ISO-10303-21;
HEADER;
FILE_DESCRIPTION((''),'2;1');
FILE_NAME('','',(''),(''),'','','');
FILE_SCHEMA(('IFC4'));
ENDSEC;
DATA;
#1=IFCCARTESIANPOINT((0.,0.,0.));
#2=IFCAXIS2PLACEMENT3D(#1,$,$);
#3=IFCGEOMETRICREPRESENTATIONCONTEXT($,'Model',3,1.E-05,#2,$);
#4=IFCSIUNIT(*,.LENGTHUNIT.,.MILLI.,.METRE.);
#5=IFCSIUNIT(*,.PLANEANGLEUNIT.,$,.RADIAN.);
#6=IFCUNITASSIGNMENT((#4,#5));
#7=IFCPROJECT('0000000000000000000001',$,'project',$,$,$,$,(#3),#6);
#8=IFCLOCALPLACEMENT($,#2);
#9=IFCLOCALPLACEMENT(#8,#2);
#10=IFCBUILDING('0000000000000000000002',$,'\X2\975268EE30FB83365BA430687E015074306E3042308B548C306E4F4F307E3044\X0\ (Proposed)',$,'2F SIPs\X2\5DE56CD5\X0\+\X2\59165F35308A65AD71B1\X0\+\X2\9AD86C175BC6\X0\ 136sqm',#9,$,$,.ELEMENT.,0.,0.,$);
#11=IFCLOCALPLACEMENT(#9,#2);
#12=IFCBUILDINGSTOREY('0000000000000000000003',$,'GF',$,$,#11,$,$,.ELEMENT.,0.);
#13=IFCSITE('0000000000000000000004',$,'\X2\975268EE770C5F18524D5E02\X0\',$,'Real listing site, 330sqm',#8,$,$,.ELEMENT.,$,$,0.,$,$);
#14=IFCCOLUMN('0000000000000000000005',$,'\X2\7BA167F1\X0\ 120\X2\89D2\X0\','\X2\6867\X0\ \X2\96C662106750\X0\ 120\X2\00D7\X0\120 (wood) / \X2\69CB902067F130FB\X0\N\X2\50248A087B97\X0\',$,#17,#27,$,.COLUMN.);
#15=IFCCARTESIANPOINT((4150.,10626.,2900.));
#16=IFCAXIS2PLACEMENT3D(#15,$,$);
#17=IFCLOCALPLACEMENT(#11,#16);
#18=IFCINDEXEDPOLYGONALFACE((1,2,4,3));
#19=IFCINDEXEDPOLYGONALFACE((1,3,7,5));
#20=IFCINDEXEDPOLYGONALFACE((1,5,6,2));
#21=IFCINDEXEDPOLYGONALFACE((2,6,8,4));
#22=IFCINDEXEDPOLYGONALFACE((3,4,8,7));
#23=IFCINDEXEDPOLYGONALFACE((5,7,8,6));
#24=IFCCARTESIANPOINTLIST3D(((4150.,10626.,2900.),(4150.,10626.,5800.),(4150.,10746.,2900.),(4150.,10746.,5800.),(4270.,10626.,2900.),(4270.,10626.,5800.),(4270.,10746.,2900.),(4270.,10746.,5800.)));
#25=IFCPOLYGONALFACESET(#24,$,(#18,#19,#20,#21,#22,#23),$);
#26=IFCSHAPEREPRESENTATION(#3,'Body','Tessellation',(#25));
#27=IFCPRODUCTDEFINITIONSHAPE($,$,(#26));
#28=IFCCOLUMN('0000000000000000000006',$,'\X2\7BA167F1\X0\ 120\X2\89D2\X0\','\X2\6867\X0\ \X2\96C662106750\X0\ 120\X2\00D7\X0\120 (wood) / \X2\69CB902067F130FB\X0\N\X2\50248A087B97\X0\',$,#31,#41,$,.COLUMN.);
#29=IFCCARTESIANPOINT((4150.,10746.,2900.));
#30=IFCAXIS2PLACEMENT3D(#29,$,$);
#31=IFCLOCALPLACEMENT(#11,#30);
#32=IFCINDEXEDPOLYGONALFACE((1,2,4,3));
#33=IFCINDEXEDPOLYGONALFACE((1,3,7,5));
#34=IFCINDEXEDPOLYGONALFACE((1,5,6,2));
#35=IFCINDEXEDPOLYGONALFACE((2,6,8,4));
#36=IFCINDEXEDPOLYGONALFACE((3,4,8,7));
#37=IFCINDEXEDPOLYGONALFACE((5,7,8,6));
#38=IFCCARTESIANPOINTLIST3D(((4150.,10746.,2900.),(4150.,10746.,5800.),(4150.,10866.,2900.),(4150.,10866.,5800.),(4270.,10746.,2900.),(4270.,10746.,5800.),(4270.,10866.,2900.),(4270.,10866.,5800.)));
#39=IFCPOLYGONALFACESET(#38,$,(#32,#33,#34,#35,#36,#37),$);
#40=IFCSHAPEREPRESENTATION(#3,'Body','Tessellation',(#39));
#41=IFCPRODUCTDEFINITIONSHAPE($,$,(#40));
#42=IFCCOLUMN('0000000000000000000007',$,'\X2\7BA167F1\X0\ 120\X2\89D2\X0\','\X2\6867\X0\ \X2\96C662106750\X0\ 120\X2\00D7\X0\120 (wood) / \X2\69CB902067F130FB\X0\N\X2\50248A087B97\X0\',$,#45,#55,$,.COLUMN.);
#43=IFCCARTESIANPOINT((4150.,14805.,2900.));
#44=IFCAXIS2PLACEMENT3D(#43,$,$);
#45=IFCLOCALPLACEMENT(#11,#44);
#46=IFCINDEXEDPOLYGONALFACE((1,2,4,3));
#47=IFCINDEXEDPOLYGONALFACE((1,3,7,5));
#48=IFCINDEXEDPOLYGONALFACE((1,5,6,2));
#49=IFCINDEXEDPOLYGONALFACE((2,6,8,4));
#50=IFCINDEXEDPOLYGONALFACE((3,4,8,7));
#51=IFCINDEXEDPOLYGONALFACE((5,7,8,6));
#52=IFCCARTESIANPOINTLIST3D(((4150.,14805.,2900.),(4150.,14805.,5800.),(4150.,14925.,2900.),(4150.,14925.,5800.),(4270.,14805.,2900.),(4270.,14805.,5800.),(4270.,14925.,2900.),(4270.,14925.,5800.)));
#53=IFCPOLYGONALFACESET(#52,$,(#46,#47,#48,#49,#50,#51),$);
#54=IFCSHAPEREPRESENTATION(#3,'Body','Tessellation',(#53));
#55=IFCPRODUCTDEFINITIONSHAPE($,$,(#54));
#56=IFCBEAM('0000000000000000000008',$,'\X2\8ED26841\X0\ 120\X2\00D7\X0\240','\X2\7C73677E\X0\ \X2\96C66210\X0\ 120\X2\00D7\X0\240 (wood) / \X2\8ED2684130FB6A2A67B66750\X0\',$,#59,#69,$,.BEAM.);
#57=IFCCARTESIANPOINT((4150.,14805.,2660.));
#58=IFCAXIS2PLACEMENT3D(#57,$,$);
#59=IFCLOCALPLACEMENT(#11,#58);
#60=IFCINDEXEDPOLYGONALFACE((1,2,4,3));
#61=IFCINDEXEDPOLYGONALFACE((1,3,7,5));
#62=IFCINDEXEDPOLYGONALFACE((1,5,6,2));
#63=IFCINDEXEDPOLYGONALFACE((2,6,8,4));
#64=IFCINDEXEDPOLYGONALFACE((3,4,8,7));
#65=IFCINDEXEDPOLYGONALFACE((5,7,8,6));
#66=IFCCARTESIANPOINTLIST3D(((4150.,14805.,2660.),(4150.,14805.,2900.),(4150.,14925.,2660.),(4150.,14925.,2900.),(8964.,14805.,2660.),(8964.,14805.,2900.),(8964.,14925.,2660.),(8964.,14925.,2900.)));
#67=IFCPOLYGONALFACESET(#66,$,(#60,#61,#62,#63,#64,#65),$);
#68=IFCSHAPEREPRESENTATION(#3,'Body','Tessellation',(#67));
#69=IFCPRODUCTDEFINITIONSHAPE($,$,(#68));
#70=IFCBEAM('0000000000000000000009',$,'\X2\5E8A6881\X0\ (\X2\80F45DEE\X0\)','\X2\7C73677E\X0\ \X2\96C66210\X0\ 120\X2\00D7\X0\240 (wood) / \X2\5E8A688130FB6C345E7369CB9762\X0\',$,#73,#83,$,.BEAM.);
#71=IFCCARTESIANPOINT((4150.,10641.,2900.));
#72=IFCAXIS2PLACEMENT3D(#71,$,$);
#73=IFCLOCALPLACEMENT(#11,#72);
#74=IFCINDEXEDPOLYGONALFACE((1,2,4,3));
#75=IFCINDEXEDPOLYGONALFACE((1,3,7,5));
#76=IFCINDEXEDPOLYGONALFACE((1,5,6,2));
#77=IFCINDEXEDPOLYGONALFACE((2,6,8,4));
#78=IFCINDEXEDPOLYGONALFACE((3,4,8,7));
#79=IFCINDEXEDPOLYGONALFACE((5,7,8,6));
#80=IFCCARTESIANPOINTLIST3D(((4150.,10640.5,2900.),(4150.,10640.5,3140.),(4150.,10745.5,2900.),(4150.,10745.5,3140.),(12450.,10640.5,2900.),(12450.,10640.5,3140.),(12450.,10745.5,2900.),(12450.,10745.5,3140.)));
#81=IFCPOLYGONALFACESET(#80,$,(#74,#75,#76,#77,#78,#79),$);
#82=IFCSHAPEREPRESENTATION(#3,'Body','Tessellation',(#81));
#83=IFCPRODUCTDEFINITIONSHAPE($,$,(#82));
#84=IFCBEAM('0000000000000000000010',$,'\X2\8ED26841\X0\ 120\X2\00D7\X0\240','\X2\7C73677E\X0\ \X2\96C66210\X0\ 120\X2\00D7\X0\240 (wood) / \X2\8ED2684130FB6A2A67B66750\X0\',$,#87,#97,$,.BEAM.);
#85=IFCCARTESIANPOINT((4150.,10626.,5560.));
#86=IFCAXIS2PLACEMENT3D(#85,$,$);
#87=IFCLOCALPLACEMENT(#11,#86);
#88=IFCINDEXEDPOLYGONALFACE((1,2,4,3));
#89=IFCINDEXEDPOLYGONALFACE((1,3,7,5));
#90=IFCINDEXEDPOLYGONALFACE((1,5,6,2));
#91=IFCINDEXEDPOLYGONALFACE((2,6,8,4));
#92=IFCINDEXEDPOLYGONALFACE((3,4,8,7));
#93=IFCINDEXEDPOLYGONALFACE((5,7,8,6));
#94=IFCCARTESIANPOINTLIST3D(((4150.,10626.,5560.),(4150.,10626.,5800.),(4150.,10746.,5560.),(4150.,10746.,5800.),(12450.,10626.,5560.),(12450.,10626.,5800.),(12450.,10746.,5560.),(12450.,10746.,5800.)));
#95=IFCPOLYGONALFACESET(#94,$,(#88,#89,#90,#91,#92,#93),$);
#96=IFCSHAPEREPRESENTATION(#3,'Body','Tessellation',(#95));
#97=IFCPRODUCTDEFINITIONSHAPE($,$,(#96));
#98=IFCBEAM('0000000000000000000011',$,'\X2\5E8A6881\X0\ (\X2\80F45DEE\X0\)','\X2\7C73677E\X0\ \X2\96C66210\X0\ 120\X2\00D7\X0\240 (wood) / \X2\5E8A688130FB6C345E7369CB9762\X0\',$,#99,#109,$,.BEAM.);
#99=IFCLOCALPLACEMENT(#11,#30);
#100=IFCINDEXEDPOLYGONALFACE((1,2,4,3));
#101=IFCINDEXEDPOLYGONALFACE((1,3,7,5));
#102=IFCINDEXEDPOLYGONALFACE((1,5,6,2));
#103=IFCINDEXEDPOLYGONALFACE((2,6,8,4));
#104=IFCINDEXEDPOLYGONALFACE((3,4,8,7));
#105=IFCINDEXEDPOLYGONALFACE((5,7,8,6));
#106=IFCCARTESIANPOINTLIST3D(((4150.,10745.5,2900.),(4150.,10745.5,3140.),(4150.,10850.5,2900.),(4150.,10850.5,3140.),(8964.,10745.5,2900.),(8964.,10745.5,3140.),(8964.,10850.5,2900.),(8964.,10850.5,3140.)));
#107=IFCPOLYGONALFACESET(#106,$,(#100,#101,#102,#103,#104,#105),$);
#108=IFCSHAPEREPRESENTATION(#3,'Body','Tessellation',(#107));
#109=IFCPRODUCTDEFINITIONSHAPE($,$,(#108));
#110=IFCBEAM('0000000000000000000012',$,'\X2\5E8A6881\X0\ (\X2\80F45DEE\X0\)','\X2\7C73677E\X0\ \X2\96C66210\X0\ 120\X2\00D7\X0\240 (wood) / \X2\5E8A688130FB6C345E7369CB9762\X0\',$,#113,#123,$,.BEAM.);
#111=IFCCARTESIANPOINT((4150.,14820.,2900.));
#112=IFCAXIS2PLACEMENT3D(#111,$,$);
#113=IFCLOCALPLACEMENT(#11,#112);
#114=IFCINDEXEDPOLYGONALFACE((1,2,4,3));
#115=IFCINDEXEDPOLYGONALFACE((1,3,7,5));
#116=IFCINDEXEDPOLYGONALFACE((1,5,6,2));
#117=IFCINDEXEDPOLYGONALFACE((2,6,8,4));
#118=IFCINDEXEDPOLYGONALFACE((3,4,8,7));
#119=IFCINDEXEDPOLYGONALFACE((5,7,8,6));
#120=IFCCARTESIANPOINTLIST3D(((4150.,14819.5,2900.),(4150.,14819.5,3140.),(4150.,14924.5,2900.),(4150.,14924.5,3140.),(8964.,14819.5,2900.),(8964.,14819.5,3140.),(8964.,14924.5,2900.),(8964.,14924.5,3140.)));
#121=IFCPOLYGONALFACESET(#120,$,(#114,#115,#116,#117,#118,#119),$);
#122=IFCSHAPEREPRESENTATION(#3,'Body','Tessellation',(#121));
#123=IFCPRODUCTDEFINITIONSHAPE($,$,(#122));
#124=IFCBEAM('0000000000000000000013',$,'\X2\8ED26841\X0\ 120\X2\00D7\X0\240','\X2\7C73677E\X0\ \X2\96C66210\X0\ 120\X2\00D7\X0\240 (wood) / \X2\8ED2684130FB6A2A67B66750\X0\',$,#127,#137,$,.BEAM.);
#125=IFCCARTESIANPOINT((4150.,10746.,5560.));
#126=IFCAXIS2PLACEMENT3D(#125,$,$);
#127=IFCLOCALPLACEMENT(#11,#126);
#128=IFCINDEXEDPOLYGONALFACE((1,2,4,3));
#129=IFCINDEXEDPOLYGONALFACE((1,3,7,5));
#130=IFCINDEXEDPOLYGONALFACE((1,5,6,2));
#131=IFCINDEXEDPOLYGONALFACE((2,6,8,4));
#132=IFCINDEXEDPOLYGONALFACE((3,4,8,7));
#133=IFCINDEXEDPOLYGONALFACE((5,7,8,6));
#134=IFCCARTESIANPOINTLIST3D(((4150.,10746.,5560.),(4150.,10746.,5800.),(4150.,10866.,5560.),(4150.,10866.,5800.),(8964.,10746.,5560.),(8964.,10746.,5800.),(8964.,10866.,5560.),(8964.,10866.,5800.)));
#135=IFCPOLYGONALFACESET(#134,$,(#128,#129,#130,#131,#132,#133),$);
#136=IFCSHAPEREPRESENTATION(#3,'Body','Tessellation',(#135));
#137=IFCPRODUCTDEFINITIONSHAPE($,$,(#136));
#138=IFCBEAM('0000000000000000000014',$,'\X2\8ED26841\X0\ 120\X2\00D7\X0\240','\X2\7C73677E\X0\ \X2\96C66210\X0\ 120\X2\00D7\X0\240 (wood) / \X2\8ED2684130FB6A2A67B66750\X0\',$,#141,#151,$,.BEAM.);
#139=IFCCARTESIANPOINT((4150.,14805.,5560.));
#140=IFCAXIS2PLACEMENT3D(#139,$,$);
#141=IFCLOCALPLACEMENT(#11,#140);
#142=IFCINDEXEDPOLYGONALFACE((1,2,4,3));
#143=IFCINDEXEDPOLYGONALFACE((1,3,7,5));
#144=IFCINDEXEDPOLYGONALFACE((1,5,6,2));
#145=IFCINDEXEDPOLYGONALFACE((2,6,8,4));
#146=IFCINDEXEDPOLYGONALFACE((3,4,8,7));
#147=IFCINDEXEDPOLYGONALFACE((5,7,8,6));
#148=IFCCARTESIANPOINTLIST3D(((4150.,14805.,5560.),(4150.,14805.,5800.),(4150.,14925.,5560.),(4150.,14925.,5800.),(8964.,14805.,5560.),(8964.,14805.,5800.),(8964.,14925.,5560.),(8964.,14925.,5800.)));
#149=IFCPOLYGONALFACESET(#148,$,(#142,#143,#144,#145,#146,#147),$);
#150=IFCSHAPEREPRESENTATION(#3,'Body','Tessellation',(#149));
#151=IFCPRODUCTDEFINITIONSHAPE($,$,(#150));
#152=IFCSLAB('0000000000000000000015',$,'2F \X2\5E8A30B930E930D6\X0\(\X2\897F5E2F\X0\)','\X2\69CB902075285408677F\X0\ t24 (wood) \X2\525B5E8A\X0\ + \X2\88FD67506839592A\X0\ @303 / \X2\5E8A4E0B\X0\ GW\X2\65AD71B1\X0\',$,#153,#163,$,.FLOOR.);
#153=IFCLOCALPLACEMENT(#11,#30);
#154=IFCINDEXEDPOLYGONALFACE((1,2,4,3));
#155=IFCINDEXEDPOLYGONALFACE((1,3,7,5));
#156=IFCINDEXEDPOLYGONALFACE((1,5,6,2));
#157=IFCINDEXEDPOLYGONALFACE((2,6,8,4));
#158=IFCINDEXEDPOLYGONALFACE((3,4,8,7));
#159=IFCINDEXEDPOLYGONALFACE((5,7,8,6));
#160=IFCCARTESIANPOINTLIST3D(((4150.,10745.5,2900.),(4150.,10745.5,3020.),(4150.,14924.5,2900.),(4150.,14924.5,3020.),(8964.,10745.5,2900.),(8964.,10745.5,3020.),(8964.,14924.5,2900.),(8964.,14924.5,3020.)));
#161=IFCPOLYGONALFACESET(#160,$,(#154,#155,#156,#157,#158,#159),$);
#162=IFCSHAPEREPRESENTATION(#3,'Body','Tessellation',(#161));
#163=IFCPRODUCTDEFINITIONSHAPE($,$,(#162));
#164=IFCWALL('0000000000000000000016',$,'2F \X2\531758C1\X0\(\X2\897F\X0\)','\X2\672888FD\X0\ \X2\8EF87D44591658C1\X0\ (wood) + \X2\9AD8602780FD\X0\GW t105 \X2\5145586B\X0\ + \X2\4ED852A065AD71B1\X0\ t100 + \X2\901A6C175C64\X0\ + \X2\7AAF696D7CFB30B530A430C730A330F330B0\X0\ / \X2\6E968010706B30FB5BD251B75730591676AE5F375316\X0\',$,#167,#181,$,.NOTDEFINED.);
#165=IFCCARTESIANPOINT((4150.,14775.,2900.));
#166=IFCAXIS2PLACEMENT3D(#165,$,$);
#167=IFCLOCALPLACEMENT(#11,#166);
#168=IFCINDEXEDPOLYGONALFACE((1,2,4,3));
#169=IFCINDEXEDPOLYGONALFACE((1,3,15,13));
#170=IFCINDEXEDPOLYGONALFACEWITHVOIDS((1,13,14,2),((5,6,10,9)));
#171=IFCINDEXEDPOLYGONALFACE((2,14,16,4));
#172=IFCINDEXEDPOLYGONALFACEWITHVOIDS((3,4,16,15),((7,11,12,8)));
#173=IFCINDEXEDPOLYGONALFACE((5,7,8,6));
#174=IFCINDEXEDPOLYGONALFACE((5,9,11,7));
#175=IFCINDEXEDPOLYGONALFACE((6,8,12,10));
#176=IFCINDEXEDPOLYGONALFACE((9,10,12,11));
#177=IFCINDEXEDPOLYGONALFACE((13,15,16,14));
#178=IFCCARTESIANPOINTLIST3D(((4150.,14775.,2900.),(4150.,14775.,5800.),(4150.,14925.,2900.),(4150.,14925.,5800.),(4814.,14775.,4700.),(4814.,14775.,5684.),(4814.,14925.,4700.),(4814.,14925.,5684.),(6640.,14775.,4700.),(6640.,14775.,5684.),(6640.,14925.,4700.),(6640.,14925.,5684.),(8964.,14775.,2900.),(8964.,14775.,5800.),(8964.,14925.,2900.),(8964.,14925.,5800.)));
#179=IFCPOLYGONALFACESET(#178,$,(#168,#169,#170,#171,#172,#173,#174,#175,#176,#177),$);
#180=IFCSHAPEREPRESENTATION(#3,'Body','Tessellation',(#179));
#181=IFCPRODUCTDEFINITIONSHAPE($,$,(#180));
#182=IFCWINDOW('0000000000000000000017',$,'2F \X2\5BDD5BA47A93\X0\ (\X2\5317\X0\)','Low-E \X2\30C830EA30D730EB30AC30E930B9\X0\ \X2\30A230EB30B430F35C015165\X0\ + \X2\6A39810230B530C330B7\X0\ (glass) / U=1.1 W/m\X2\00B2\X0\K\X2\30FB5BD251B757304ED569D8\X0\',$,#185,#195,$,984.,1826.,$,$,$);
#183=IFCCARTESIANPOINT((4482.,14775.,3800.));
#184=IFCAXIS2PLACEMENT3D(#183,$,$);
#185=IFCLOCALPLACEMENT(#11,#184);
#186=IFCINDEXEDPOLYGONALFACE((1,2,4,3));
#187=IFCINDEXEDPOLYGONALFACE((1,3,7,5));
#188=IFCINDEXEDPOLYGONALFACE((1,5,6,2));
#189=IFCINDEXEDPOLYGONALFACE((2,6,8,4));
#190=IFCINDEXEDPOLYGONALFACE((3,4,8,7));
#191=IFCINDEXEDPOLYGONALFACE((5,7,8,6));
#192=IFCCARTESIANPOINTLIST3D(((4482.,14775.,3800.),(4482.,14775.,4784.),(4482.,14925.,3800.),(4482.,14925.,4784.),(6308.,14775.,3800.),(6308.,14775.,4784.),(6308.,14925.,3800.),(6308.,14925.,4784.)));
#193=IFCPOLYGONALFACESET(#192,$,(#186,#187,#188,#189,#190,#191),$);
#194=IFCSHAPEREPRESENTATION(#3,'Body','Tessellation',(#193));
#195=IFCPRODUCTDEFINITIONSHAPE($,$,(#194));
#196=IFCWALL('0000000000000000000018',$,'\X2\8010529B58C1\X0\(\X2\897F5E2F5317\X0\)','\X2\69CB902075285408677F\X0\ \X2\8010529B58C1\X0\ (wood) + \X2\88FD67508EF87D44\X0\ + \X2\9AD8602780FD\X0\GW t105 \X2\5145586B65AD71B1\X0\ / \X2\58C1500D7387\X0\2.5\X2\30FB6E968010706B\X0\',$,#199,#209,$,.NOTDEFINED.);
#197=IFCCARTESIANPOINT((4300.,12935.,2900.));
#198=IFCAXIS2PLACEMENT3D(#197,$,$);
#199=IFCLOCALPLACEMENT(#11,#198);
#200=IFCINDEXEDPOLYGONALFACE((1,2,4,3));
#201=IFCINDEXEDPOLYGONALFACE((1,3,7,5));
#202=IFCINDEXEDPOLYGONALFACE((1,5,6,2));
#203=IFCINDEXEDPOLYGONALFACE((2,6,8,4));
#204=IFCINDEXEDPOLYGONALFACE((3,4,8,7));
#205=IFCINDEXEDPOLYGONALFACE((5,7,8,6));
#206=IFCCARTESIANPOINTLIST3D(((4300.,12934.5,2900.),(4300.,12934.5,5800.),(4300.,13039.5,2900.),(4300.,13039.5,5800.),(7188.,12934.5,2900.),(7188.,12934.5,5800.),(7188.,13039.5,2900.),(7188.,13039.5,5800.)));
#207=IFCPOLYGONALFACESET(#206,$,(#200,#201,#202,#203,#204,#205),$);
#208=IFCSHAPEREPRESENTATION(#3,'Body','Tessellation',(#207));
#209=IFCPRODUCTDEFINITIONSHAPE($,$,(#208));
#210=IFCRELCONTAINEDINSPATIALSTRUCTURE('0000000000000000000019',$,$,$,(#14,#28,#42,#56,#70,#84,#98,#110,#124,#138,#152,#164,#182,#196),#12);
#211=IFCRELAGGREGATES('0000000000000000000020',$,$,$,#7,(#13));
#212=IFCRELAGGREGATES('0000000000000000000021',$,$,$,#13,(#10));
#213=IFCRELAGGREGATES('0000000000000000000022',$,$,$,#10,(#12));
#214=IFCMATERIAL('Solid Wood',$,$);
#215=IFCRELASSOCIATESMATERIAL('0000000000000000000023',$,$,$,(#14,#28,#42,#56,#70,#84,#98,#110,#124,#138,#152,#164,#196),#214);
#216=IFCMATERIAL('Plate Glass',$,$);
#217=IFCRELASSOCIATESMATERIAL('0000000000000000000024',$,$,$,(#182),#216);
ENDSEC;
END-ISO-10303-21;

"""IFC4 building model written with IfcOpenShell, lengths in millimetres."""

from ifc_helpers import new_model, si_unit, frame, frame_2d, origin, place, context, project, spatial, rectangle, extrude, material, element, fill, save


model = new_model("IFC4")

# Units and contexts
model_context = context("Model", 3, precision=1e-05, world=origin())
ifc_project = project(units=[si_unit("LENGTHUNIT", "METRE", prefix="MILLI"), si_unit("PLANEANGLEUNIT", "RADIAN")], contexts=[model_context])

# Site, building, storey
site_placement = place(None, origin())
site = spatial("IfcSite", under=ifc_project, at=site_placement, Name="青森県弘前市", ObjectType="Real listing site, 330sqm", CompositionType="ELEMENT", RefElevation=0.0)
building_placement = place(site_placement, origin())
building = spatial("IfcBuilding", under=site, at=building_placement, Name="青森・茶室と縁側のある和の住まい (Proposed)", ObjectType="2F SIPs工法+外張り断熱+高気密 136sqm", CompositionType="ELEMENT", ElevationOfRefHeight=0.0, ElevationOfTerrain=0.0)
storey_placement = place(building_placement, origin())
storey = spatial("IfcBuildingStorey", under=building, at=storey_placement, Name="GF", CompositionType="ELEMENT", Elevation=0.0)

# Columns
ifc_material_1 = material(Name="Solid Wood")
column_1_placement = place(storey_placement, frame((4150.0, 10626.0, 2900.0)))
element("IfcColumn", 1, at=column_1_placement, inside=storey, material=ifc_material_1, Name="管柱 120角", Description="桧 集成材 120×120 (wood) / 構造柱・N値計算", PredefinedType="COLUMN", context=model_context, shape_type="SweptSolid", body=[
    extrude(rectangle(XDim=120.0, YDim=120.0, at=frame_2d((60.0, 60.0))), frame((4150.0, 10626.0, 2900.0)), (0.0, 0.0, 1.0), 2900.0),
])
column_2_placement = place(storey_placement, frame((4150.0, 10746.0, 2900.0)))
element("IfcColumn", 2, at=column_2_placement, inside=storey, material=ifc_material_1, Name="管柱 120角", Description="桧 集成材 120×120 (wood) / 構造柱・N値計算", PredefinedType="COLUMN", context=model_context, shape_type="SweptSolid", body=[
    extrude(rectangle(XDim=120.0, YDim=120.0, at=frame_2d((60.0, 60.0))), frame((4150.0, 10746.0, 2900.0)), (0.0, 0.0, 1.0), 2900.0),
])
column_3_placement = place(storey_placement, frame((4150.0, 14805.0, 2900.0)))
element("IfcColumn", 3, at=column_3_placement, inside=storey, material=ifc_material_1, Name="管柱 120角", Description="桧 集成材 120×120 (wood) / 構造柱・N値計算", PredefinedType="COLUMN", context=model_context, shape_type="SweptSolid", body=[
    extrude(rectangle(XDim=120.0, YDim=120.0, at=frame_2d((60.0, 60.0))), frame((4150.0, 14805.0, 2900.0)), (0.0, 0.0, 1.0), 2900.0),
])

# Beams
beam_1_placement = place(storey_placement, frame((4150.0, 14805.0, 2660.0)))
element("IfcBeam", 4, at=beam_1_placement, inside=storey, material=ifc_material_1, Name="軒桁 120×240", Description="米松 集成 120×240 (wood) / 軒桁・横架材", PredefinedType="BEAM", context=model_context, shape_type="SweptSolid", body=[
    extrude(rectangle(XDim=4814.0, YDim=120.0, at=frame_2d((2407.0, 60.0))), frame((4150.0, 14805.0, 2660.0)), (0.0, 0.0, 1.0), 240.0),
])
beam_2_placement = place(storey_placement, frame((4150.0, 10641.0, 2900.0)))
element("IfcBeam", 5, at=beam_2_placement, inside=storey, material=ifc_material_1, Name="床梁 (胴差)", Description="米松 集成 120×240 (wood) / 床梁・水平構面", PredefinedType="BEAM", context=model_context, shape_type="SweptSolid", body=[
    extrude(rectangle(XDim=8300.0, YDim=105.0, at=frame_2d((4150.0, 52.0))), frame((4150.0, 10641.0, 2900.0)), (0.0, 0.0, 1.0), 240.0),
])
beam_3_placement = place(storey_placement, frame((4150.0, 10626.0, 5560.0)))
element("IfcBeam", 6, at=beam_3_placement, inside=storey, material=ifc_material_1, Name="軒桁 120×240", Description="米松 集成 120×240 (wood) / 軒桁・横架材", PredefinedType="BEAM", context=model_context, shape_type="SweptSolid", body=[
    extrude(rectangle(XDim=8300.0, YDim=120.0, at=frame_2d((4150.0, 60.0))), frame((4150.0, 10626.0, 5560.0)), (0.0, 0.0, 1.0), 240.0),
])
beam_4_placement = place(storey_placement, frame((4150.0, 10746.0, 2900.0)))
element("IfcBeam", 7, at=beam_4_placement, inside=storey, material=ifc_material_1, Name="床梁 (胴差)", Description="米松 集成 120×240 (wood) / 床梁・水平構面", PredefinedType="BEAM", context=model_context, shape_type="SweptSolid", body=[
    extrude(rectangle(XDim=4814.0, YDim=105.0, at=frame_2d((2407.0, 52.0))), frame((4150.0, 10746.0, 2900.0)), (0.0, 0.0, 1.0), 240.0),
])
beam_5_placement = place(storey_placement, frame((4150.0, 14820.0, 2900.0)))
element("IfcBeam", 8, at=beam_5_placement, inside=storey, material=ifc_material_1, Name="床梁 (胴差)", Description="米松 集成 120×240 (wood) / 床梁・水平構面", PredefinedType="BEAM", context=model_context, shape_type="SweptSolid", body=[
    extrude(rectangle(XDim=4814.0, YDim=105.0, at=frame_2d((2407.0, 52.0))), frame((4150.0, 14820.0, 2900.0)), (0.0, 0.0, 1.0), 240.0),
])
beam_6_placement = place(storey_placement, frame((4150.0, 10746.0, 5560.0)))
element("IfcBeam", 9, at=beam_6_placement, inside=storey, material=ifc_material_1, Name="軒桁 120×240", Description="米松 集成 120×240 (wood) / 軒桁・横架材", PredefinedType="BEAM", context=model_context, shape_type="SweptSolid", body=[
    extrude(rectangle(XDim=4814.0, YDim=120.0, at=frame_2d((2407.0, 60.0))), frame((4150.0, 10746.0, 5560.0)), (0.0, 0.0, 1.0), 240.0),
])
beam_7_placement = place(storey_placement, frame((4150.0, 14805.0, 5560.0)))
element("IfcBeam", 10, at=beam_7_placement, inside=storey, material=ifc_material_1, Name="軒桁 120×240", Description="米松 集成 120×240 (wood) / 軒桁・横架材", PredefinedType="BEAM", context=model_context, shape_type="SweptSolid", body=[
    extrude(rectangle(XDim=4814.0, YDim=120.0, at=frame_2d((2407.0, 60.0))), frame((4150.0, 14805.0, 5560.0)), (0.0, 0.0, 1.0), 240.0),
])

# Slab
slab_placement = place(storey_placement, frame((4150.0, 10746.0, 2900.0)))
element("IfcSlab", 11, at=slab_placement, inside=storey, material=ifc_material_1, Name="2F 床スラブ(西帯)", Description="構造用合板 t24 (wood) 剛床 + 製材根太 @303 / 床下 GW断熱", PredefinedType="FLOOR", context=model_context, shape_type="SweptSolid", body=[
    extrude(rectangle(XDim=4814.0, YDim=4179.0, at=frame_2d((2407.0, 2089.0))), frame((4150.0, 10746.0, 2900.0)), (0.0, 0.0, 1.0), 120.0),
])

# Wall, opening, window
wall_1_placement = place(storey_placement, frame((4150.0, 14775.0, 2900.0)))
wall_1 = element("IfcWall", 12, at=wall_1_placement, inside=storey, material=ifc_material_1, Name="2F 北壁(西)", Description="木製 軸組外壁 (wood) + 高性能GW t105 充填 + 付加断熱 t100 + 通気層 + 窯業系サイディング / 準耐火・寒冷地外皮強化", PredefinedType="NOTDEFINED", context=model_context, shape_type="SweptSolid", body=[
    extrude(rectangle(XDim=4814.0, YDim=150.0, at=frame_2d((2407.0, 75.0))), frame((4150.0, 14775.0, 2900.0)), (0.0, 0.0, 1.0), 2900.0),
])
opening_placement = place(storey_placement, frame((4482.0, 14775.0, 3800.0)))
opening = element("IfcOpeningElement", 13, at=opening_placement, cuts=wall_1, PredefinedType="NOTDEFINED", context=model_context, shape_type="SweptSolid", body=[
    extrude(rectangle(XDim=1826.0, YDim=150.0, at=frame_2d((913.0, 75.0))), frame((4482.0, 14775.0, 3800.0)), (0.0, 0.0, 1.0), 984.0),
])
ifc_material_2 = material(Name="Plate Glass")
window_placement = place(storey_placement, frame((4482.0, 14775.0, 3800.0)))
window = element("IfcWindow", 14, at=window_placement, inside=storey, material=ifc_material_2, Name="2F 寝室窓 (北)", Description="Low-E トリプルガラス アルゴン封入 + 樹脂サッシ (glass) / U=1.1 W/m²K・寒冷地仕様", OverallHeight=984.0, OverallWidth=1826.0, context=model_context, shape_type="SweptSolid", body=[
    extrude(rectangle(XDim=1826.0, YDim=150.0, at=frame_2d((913.0, 75.0))), frame((4482.0, 14775.0, 3800.0)), (0.0, 0.0, 1.0), 984.0),
])
fill(opening, window)

# Wall
wall_2_placement = place(storey_placement, frame((4300.0, 12935.0, 2900.0)))
element("IfcWall", 15, at=wall_2_placement, inside=storey, material=ifc_material_1, Name="耐力壁(西帯北)", Description="構造用合板 耐力壁 (wood) + 製材軸組 + 高性能GW t105 充填断熱 / 壁倍率2.5・準耐火", PredefinedType="NOTDEFINED", context=model_context, shape_type="SweptSolid", body=[
    extrude(rectangle(XDim=2888.0, YDim=105.0, at=frame_2d((1444.0, 52.0))), frame((4300.0, 12935.0, 2900.0)), (0.0, 0.0, 1.0), 2900.0),
])

save(model, "model.ifc")
